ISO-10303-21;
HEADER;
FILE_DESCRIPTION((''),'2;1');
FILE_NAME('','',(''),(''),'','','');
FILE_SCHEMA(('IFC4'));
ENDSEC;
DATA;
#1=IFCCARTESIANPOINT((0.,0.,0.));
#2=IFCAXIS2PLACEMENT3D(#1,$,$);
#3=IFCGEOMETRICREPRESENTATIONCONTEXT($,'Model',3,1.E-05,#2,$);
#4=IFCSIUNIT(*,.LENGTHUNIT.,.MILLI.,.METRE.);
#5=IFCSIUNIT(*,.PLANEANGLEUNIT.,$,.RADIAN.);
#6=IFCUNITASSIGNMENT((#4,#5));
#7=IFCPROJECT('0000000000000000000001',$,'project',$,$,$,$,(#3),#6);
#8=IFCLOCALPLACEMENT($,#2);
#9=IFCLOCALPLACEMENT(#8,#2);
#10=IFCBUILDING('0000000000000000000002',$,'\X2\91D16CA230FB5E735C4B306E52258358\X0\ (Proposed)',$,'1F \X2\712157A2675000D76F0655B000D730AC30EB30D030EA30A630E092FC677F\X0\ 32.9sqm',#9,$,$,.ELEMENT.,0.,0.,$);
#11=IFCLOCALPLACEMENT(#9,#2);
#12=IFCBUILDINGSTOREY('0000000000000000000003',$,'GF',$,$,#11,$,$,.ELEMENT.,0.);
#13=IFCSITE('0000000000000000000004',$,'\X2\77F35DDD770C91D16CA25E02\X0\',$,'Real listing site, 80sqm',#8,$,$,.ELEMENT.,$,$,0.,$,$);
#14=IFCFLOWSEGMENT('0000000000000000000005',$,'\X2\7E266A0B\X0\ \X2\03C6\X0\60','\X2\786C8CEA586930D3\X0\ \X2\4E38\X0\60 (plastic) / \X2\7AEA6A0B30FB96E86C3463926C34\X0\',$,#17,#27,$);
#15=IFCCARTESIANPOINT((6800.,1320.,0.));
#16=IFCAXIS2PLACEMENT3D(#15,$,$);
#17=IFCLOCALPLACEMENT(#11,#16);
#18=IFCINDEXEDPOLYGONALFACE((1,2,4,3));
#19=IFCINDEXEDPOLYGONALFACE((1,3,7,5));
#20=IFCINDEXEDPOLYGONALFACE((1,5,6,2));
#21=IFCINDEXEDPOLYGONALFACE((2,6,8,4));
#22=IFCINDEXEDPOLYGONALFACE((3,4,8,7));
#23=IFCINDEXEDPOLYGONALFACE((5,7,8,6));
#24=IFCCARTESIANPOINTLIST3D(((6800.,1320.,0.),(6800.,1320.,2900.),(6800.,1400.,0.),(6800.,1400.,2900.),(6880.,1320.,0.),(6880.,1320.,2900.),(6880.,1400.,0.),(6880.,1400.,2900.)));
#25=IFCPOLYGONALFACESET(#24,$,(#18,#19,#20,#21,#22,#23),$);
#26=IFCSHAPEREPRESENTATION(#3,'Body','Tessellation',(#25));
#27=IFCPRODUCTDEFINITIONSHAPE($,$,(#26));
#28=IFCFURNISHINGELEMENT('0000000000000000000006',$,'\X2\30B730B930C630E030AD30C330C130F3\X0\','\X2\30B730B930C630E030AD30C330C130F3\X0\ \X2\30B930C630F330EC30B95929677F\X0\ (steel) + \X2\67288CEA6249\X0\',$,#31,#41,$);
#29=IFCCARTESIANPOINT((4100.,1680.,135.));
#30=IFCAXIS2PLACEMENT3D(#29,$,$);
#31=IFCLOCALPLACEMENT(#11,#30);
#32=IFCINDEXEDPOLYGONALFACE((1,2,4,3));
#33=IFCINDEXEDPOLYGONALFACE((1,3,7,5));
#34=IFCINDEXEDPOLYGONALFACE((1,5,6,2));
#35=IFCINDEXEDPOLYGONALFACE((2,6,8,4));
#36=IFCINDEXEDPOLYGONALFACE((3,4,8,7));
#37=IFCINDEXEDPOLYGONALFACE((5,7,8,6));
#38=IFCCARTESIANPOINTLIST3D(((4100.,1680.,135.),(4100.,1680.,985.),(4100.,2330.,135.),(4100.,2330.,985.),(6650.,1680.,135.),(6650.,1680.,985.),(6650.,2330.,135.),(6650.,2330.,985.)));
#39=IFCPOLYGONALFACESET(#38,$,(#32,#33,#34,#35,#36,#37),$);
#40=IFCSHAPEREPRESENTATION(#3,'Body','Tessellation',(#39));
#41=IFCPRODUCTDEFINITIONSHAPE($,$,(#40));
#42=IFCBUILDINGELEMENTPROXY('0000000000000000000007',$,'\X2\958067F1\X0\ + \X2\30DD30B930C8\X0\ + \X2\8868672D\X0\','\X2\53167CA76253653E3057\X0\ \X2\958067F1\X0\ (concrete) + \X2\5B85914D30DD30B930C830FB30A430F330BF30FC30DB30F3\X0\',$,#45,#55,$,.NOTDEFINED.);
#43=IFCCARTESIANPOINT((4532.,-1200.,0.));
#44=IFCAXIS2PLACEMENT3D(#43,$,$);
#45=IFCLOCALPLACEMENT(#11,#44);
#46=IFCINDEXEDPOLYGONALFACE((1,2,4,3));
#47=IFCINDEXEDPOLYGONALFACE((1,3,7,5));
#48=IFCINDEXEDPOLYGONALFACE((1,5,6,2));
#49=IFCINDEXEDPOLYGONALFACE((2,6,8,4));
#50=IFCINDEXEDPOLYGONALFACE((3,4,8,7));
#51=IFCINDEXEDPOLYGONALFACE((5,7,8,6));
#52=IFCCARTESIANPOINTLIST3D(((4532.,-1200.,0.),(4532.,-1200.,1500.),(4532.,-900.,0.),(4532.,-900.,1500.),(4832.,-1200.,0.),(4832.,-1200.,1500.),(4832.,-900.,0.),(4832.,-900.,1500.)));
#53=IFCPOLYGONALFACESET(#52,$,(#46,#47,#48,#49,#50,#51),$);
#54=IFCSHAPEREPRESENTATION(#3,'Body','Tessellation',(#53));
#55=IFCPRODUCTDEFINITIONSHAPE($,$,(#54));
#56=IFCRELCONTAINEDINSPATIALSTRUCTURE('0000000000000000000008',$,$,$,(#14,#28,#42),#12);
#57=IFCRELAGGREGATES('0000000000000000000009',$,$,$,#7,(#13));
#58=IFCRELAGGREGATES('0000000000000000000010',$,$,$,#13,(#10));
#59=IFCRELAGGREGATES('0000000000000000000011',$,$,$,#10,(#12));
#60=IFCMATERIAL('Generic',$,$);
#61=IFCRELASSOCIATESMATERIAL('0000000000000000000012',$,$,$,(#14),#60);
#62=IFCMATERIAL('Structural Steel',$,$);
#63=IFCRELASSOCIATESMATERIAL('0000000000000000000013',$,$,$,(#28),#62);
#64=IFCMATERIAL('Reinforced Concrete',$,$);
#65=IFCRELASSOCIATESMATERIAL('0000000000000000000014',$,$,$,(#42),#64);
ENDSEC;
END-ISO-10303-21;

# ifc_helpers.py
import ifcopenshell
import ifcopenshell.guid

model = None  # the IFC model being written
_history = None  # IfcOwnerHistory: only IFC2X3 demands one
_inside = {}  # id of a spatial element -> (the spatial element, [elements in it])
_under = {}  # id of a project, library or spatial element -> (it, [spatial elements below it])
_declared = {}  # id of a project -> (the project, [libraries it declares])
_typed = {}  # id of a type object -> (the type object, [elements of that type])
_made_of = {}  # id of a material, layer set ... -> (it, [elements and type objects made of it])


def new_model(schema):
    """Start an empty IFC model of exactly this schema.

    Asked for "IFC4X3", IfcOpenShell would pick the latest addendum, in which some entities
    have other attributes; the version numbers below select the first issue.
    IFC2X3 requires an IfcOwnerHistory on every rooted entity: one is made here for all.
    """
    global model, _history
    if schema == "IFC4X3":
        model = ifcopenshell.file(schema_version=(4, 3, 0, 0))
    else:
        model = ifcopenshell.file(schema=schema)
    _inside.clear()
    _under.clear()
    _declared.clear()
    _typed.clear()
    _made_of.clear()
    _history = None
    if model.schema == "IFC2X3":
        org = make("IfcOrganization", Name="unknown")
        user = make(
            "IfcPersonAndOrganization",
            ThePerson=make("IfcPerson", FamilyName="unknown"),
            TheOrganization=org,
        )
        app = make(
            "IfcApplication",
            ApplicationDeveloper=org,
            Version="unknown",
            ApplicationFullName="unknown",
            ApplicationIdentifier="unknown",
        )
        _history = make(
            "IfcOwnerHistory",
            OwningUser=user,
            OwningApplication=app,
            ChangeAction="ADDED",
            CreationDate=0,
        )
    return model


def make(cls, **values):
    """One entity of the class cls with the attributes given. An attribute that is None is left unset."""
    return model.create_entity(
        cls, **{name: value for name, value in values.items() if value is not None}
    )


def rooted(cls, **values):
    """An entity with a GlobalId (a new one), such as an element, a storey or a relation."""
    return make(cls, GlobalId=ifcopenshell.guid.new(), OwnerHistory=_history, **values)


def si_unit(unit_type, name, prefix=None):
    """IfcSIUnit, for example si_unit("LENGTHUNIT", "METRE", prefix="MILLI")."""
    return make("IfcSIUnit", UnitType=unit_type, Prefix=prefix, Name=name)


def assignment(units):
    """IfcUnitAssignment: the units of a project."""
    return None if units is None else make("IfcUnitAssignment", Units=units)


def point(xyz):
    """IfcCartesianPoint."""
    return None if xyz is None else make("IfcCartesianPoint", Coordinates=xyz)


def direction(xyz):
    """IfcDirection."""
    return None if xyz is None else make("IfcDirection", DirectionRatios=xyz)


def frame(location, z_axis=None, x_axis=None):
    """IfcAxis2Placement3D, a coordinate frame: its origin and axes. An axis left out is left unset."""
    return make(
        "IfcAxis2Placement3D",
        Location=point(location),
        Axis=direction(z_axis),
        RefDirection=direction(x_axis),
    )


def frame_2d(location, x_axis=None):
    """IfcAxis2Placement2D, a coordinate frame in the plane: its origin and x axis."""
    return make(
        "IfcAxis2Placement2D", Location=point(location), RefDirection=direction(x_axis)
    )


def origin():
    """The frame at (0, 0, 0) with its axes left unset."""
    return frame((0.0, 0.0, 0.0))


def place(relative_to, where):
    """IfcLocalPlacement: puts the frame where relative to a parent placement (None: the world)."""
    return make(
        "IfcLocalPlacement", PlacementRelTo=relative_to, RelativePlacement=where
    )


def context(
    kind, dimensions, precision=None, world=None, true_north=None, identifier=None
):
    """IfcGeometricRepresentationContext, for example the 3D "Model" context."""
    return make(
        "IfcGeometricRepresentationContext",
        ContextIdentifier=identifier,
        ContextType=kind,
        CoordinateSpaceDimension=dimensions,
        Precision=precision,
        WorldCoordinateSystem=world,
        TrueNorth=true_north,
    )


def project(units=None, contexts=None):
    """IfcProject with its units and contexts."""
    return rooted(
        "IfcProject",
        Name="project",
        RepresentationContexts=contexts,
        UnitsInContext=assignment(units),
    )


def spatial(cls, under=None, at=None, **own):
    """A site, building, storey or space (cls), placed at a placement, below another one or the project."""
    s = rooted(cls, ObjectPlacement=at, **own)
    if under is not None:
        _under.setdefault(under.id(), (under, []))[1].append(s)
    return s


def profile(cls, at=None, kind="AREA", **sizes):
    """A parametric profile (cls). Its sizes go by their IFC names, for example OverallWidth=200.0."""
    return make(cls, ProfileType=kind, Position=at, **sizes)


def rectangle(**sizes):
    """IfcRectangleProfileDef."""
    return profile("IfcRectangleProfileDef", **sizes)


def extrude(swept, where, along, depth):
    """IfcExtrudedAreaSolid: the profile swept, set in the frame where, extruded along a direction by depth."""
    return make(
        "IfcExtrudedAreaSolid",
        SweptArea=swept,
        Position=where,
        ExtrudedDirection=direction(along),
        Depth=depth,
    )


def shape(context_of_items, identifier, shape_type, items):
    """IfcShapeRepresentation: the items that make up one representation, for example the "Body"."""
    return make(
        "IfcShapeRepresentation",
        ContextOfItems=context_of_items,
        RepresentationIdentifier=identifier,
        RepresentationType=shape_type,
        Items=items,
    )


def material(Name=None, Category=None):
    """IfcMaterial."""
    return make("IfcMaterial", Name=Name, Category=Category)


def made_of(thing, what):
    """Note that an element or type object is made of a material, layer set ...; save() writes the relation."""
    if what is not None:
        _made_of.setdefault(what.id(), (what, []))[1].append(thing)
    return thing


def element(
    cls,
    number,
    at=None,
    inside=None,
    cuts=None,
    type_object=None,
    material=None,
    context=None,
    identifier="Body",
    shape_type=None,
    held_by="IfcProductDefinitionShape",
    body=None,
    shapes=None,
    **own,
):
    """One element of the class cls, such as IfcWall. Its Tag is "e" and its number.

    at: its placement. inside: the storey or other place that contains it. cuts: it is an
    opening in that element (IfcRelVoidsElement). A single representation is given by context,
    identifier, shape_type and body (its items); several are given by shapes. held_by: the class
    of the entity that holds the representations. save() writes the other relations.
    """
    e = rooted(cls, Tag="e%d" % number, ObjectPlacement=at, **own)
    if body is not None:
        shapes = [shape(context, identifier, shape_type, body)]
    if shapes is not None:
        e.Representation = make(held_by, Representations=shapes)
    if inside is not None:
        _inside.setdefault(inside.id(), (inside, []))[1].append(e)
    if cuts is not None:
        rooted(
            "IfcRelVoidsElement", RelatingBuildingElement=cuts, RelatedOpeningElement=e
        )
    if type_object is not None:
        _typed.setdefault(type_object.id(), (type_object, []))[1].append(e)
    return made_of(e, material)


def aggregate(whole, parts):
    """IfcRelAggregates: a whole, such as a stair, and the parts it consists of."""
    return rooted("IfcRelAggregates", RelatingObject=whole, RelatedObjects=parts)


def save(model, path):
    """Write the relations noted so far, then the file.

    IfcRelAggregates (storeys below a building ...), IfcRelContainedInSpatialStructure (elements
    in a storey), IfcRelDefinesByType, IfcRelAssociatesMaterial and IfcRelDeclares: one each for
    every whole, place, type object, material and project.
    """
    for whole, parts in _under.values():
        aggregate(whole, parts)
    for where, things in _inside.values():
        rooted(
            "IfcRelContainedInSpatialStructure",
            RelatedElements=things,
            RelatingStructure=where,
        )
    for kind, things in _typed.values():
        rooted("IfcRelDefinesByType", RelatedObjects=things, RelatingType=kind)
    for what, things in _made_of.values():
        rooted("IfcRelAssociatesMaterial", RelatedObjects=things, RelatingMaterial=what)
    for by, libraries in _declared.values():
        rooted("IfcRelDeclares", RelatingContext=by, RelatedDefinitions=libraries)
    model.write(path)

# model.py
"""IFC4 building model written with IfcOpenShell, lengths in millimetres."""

from ifc_helpers import new_model, si_unit, frame, frame_2d, origin, place, context, project, spatial, rectangle, extrude, material, element, save


model = new_model("IFC4")

# Units and contexts
model_context = context("Model", 3, precision=1e-05, world=origin())
ifc_project = project(units=[si_unit("LENGTHUNIT", "METRE", prefix="MILLI"), si_unit("PLANEANGLEUNIT", "RADIAN")], contexts=[model_context])

# Site, building, storey
site_placement = place(None, origin())
site = spatial("IfcSite", under=ifc_project, at=site_placement, Name="石川県金沢市", ObjectType="Real listing site, 80sqm", CompositionType="ELEMENT", RefElevation=0.0)
building_placement = place(site_placement, origin())
building = spatial("IfcBuilding", under=site, at=building_placement, Name="金沢・平屋の別荘 (Proposed)", ObjectType="1F 無垢材×漆喰×ガルバリウム鋼板 32.9sqm", CompositionType="ELEMENT", ElevationOfRefHeight=0.0, ElevationOfTerrain=0.0)
storey_placement = place(building_placement, origin())
storey = spatial("IfcBuildingStorey", under=building, at=storey_placement, Name="GF", CompositionType="ELEMENT", Elevation=0.0)

# Shared definitions
ifc_material_1 = material(Name="Reinforced Concrete")

# Shared definitions
ifc_material_2 = material(Name="Structural Steel")

# Shared definitions
ifc_material_3 = material(Name="Generic")

# Flow segment
flow_segment_1_placement = place(storey_placement, frame((6800.0, 1320.0, 0.0)))
element("IfcFlowSegment", 1, at=flow_segment_1_placement, inside=storey, material=ifc_material_3, Name="縦樋 φ60", Description="硬質塩ビ 丸60 (plastic) / 竪樋・雨水排水", context=model_context, shape_type="SweptSolid", body=[
    extrude(rectangle(XDim=80.0, YDim=80.0, at=frame_2d((40.0, 40.0))), frame((6800.0, 1320.0, 0.0)), (0.0, 0.0, 1.0), 2900.0),
])

# Furnishing element
furnishing_placement = place(storey_placement, frame((4100.0, 1680.0, 135.0)))
element("IfcFurnishingElement", 2, at=furnishing_placement, inside=storey, material=ifc_material_2, Name="システムキッチン", Description="システムキッチン ステンレス天板 (steel) + 木質扉", context=model_context, shape_type="SweptSolid", body=[
    extrude(rectangle(XDim=2550.0, YDim=650.0, at=frame_2d((1275.0, 325.0))), frame((4100.0, 1680.0, 135.0)), (0.0, 0.0, 1.0), 850.0),
])

# Building element proxy
proxy_placement = place(storey_placement, frame((4532.0, -1200.0, 0.0)))
element("IfcBuildingElementProxy", 3, at=proxy_placement, inside=storey, material=ifc_material_1, Name="門柱 + ポスト + 表札", Description="化粧打放し 門柱 (concrete) + 宅配ポスト・インターホン", PredefinedType="NOTDEFINED", context=model_context, shape_type="SweptSolid", body=[
    extrude(rectangle(XDim=300.0, YDim=300.0, at=frame_2d((150.0, 150.0))), frame((4532.0, -1200.0, 0.0)), (0.0, 0.0, 1.0), 1500.0),
])

save(model, "model.ifc")
